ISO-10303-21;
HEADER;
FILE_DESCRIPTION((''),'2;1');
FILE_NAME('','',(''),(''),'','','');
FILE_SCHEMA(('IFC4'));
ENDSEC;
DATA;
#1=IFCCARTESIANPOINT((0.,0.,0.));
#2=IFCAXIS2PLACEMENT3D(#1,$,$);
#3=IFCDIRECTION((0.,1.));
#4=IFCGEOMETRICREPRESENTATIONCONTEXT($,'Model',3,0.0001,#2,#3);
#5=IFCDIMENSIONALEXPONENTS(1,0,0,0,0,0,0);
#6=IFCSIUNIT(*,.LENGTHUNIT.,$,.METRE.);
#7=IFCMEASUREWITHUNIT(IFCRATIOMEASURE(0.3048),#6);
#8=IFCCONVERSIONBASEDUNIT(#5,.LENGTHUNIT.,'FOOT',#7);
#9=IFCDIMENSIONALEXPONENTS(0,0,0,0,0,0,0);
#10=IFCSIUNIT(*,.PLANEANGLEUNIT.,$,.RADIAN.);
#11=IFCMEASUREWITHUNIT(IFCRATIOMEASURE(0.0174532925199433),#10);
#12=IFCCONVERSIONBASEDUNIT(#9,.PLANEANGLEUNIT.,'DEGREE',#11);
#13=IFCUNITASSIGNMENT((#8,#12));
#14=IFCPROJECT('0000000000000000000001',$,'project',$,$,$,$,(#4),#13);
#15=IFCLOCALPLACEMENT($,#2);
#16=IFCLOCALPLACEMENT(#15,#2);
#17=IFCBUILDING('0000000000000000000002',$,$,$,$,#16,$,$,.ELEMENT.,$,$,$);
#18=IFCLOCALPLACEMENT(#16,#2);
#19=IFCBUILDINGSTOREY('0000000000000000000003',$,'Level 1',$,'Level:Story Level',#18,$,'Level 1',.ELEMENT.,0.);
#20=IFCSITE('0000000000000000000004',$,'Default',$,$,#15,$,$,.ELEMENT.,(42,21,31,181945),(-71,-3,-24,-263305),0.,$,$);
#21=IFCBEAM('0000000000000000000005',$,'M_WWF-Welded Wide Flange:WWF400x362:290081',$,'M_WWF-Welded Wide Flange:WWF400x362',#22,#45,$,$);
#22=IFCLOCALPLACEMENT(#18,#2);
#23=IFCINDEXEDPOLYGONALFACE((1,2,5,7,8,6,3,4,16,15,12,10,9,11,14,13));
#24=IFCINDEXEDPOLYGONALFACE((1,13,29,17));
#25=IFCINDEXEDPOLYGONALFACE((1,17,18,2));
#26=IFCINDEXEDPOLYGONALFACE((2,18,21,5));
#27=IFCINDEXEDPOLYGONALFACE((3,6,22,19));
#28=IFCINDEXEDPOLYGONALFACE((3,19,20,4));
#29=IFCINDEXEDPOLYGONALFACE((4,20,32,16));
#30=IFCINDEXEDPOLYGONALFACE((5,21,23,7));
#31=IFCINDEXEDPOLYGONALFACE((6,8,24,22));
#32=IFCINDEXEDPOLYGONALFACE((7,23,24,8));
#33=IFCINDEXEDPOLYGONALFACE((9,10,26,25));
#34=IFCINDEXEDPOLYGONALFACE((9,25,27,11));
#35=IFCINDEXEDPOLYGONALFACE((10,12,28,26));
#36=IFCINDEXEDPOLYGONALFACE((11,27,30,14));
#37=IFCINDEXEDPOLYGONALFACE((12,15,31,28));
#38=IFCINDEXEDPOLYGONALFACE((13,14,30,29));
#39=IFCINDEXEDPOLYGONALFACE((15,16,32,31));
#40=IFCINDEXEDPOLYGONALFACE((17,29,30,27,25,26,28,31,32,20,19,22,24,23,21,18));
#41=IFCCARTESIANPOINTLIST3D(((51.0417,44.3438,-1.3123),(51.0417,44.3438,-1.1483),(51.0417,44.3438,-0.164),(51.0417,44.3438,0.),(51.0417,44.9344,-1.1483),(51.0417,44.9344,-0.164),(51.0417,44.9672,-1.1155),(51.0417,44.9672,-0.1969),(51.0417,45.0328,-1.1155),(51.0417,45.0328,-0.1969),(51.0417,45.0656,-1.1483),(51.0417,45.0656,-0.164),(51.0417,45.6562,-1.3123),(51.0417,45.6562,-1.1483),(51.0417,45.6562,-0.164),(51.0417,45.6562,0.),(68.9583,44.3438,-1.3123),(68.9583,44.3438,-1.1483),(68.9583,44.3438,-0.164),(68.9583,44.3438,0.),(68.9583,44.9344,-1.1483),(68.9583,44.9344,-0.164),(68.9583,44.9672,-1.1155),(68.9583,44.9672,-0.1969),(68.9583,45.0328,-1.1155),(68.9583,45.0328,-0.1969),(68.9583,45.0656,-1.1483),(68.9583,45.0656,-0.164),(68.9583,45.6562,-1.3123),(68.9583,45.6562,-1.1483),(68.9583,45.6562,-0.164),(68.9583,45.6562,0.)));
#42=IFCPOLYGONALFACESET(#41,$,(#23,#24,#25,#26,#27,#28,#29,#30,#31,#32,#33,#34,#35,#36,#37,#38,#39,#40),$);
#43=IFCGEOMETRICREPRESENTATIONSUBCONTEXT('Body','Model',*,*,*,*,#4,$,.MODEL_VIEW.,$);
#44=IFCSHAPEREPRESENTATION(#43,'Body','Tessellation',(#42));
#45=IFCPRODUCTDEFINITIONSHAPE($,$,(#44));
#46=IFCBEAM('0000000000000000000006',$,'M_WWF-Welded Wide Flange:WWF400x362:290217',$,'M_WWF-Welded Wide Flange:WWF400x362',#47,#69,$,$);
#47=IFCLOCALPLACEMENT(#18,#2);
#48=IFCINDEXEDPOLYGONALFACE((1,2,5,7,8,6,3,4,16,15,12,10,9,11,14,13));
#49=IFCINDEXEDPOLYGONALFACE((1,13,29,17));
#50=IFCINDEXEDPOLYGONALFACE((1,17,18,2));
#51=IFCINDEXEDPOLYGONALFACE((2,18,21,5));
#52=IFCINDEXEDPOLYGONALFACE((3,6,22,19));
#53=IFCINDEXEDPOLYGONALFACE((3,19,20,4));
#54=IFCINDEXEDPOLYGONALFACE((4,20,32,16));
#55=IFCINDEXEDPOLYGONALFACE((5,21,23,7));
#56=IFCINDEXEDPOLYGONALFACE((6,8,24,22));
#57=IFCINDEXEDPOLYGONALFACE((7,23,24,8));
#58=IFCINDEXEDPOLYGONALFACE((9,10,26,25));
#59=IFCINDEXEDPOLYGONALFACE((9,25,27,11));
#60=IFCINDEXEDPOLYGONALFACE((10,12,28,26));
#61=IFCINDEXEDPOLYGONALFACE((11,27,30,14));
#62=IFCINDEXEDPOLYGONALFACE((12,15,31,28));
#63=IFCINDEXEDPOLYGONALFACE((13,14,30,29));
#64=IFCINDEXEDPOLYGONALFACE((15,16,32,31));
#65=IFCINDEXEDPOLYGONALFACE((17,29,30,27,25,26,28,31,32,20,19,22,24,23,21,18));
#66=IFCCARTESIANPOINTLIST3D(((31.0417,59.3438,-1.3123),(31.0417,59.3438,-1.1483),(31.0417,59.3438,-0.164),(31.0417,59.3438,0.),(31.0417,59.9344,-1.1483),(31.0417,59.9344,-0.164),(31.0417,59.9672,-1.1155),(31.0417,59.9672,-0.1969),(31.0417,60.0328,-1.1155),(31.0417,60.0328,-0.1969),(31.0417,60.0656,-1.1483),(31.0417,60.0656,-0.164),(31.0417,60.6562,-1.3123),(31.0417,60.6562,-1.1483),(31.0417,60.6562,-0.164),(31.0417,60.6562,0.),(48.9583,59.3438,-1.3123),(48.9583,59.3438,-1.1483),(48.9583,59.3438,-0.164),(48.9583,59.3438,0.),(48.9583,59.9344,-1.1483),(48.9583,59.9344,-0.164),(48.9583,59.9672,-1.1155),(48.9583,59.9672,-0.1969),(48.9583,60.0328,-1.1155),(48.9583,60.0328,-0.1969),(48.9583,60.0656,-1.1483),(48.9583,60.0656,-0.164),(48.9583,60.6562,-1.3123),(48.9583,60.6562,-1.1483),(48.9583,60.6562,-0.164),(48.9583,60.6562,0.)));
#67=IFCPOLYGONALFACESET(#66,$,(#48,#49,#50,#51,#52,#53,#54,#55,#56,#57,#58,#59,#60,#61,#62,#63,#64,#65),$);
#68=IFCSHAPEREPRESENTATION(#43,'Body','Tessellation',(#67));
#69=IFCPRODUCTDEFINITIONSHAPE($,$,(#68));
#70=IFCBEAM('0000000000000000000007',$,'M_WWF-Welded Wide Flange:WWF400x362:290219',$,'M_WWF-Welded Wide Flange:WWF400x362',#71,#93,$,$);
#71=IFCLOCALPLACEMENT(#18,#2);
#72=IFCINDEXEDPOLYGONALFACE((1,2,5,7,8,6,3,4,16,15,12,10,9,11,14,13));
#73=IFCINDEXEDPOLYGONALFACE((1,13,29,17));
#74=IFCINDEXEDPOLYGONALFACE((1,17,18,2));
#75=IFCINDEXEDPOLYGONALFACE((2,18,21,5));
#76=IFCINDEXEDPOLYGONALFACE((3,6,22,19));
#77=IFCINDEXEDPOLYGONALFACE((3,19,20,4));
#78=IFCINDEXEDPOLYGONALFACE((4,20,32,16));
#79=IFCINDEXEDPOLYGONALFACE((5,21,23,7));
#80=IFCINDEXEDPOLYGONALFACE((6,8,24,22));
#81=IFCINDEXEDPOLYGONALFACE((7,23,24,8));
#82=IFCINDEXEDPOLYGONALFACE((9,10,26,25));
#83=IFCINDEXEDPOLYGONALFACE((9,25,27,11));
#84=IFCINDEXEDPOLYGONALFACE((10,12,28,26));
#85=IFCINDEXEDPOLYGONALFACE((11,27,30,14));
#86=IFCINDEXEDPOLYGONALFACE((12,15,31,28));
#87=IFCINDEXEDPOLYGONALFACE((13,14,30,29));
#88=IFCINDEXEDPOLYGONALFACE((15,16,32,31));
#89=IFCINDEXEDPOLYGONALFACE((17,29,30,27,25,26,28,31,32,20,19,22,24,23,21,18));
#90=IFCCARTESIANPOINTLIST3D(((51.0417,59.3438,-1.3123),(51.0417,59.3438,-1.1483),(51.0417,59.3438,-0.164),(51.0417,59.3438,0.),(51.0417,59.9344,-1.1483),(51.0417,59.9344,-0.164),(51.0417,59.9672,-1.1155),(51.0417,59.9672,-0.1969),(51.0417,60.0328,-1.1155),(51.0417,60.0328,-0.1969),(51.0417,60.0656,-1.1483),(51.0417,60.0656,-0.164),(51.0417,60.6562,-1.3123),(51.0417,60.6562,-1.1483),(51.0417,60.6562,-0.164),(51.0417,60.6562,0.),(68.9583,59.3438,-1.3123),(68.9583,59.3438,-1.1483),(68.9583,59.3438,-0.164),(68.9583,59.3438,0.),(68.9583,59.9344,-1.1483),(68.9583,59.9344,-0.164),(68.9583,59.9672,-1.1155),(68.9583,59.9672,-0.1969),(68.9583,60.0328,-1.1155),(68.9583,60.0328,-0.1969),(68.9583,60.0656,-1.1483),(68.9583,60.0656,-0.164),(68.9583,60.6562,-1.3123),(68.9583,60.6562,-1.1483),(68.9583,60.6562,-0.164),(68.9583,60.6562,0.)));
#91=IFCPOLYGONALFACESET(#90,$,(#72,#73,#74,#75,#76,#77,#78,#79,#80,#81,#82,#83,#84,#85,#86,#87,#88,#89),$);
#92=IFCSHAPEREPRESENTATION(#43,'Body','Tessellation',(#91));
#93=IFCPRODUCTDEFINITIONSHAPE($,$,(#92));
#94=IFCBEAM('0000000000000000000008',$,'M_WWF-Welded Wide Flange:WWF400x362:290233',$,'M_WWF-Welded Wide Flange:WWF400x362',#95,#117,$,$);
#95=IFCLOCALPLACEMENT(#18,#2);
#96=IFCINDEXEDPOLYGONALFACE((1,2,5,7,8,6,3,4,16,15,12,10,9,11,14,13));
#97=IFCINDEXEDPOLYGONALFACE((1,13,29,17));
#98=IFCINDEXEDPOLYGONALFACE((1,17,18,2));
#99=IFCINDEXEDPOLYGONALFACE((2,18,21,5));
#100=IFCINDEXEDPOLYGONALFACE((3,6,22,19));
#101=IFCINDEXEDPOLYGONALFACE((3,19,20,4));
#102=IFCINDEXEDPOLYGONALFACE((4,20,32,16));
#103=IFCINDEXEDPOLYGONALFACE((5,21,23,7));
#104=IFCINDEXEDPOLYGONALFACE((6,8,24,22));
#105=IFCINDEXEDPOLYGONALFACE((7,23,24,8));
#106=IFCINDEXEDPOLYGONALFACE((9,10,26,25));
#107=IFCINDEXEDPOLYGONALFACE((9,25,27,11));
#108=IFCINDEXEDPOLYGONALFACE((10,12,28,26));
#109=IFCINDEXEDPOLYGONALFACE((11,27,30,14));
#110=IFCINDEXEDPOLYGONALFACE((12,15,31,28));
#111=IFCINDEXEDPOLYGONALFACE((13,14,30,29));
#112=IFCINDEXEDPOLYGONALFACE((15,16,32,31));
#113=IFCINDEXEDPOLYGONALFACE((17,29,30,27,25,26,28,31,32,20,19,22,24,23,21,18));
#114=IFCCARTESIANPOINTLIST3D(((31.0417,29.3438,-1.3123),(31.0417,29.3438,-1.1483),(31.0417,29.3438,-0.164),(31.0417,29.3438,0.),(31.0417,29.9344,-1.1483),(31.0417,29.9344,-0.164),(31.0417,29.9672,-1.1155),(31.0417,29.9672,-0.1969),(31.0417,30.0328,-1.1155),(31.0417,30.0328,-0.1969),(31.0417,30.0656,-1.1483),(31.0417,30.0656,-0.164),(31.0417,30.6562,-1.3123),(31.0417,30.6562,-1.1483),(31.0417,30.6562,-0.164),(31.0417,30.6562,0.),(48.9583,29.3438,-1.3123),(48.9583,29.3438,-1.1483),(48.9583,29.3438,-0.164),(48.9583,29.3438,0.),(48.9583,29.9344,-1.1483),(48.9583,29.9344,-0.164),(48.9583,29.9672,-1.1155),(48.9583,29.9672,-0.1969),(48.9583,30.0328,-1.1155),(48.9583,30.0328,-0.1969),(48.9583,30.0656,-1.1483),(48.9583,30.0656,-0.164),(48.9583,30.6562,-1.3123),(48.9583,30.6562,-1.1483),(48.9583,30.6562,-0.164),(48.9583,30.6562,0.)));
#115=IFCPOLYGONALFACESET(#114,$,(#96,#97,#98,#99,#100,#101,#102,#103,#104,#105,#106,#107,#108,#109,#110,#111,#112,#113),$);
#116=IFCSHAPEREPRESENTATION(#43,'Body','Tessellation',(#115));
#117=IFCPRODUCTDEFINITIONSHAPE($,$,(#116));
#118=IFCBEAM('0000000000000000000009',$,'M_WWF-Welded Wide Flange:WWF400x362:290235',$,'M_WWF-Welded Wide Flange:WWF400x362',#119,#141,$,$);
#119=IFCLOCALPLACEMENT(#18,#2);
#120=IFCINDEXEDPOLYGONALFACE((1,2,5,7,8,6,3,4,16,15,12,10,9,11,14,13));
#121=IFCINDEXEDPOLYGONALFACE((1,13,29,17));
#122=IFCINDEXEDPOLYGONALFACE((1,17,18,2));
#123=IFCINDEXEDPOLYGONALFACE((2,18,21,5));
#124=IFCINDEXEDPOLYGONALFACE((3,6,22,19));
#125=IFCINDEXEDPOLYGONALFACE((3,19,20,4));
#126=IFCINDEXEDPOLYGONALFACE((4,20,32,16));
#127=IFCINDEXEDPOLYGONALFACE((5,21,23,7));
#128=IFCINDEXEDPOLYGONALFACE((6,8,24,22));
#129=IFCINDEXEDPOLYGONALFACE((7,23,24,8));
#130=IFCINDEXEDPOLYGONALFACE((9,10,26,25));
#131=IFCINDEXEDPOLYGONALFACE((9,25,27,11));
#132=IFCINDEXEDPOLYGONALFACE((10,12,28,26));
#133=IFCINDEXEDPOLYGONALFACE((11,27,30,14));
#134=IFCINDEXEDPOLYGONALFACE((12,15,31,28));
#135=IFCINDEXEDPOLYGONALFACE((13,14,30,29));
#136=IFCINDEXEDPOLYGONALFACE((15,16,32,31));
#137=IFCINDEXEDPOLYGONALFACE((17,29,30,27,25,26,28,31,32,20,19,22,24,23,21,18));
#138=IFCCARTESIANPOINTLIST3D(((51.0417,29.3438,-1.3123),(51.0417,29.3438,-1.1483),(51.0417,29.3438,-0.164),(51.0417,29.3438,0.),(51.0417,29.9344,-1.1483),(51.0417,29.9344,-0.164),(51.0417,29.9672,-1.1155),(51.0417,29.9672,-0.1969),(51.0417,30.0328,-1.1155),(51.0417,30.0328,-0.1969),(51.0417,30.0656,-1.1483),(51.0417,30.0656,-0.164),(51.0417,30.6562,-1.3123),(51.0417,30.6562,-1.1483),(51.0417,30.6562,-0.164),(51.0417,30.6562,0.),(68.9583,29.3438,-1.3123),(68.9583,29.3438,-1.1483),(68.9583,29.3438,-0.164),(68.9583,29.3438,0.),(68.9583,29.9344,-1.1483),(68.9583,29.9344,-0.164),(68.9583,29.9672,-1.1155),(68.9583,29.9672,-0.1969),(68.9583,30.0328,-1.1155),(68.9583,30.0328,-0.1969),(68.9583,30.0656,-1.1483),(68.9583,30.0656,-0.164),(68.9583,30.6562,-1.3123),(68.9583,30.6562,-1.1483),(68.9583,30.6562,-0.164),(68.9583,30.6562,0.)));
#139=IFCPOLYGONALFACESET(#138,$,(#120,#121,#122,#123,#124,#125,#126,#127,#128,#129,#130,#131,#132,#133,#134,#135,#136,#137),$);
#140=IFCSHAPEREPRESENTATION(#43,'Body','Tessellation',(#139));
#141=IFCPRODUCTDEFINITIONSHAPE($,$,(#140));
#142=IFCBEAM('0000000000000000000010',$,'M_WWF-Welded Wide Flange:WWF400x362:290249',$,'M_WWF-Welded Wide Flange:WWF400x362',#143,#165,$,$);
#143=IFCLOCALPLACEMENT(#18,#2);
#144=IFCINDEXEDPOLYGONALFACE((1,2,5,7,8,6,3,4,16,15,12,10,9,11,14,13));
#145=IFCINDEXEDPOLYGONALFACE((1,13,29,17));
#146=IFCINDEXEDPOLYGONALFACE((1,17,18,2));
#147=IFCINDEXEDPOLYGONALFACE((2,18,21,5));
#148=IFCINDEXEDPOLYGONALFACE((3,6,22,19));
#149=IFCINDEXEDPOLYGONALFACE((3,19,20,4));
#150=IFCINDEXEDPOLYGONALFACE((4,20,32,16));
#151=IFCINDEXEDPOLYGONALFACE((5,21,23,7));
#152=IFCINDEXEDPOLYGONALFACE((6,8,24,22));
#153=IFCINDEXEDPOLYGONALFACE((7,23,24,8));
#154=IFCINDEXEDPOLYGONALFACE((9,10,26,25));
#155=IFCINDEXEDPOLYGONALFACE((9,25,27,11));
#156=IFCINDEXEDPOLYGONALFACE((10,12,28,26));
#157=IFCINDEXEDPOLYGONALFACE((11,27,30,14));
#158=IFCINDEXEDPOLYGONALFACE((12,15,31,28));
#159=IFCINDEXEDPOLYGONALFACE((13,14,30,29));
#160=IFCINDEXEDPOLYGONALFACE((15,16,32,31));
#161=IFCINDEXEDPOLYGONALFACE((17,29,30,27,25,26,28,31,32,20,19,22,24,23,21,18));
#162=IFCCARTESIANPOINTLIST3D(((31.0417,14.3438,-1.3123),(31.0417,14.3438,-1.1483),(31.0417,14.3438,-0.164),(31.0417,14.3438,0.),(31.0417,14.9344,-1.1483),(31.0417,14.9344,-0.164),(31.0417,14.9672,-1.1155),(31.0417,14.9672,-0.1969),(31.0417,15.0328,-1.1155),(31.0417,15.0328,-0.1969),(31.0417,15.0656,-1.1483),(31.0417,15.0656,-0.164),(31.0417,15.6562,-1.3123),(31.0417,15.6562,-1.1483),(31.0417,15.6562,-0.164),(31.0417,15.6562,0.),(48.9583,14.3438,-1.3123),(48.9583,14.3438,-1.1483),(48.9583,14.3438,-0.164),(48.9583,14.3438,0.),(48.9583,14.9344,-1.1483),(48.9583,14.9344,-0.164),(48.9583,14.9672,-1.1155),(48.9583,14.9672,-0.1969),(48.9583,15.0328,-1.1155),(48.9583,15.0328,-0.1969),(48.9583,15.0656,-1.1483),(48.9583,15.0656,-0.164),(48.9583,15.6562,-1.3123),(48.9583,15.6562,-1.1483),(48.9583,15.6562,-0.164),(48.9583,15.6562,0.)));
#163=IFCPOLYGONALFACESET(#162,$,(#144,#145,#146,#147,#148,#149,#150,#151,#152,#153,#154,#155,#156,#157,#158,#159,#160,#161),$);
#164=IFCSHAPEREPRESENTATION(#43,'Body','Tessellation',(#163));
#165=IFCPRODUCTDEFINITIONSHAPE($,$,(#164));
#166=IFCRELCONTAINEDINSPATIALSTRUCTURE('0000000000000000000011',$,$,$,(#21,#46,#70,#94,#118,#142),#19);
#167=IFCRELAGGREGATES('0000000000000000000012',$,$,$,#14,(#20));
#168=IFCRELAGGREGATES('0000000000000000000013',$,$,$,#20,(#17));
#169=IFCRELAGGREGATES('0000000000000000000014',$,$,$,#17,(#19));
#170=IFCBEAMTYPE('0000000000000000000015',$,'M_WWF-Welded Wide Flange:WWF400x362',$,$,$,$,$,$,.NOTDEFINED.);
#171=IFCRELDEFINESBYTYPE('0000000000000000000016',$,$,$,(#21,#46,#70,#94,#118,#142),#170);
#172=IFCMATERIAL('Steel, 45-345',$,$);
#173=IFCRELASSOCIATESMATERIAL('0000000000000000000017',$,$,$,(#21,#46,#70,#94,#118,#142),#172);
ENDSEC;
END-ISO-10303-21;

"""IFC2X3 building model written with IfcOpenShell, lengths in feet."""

from ifc_helpers import new_model, entity, si_unit, converted_unit, direction, frame, origin, place, context, subcontext, project, spatial, polyline, outline, extrude, material, type_object, element, save


model = new_model("IFC2X3")

# Units and contexts
model_context = context("Model", 3, precision=0.0001, world=origin(), true_north=direction((0.0, 1.0)))
body_context = subcontext(model_context, "Body", "Model", "MODEL_VIEW")
ifc_project = project(units=[converted_unit("LENGTHUNIT", "FOOT", entity("IfcRatioMeasure", 0.3048), si_unit("LENGTHUNIT", "METRE"), dimensions=[1, 0, 0, 0, 0, 0, 0]), converted_unit("PLANEANGLEUNIT", "DEGREE", entity("IfcRatioMeasure", 0.0174532925199433), si_unit("PLANEANGLEUNIT", "RADIAN"), dimensions=[0, 0, 0, 0, 0, 0, 0])], contexts=[model_context])

# Site, building, storey
site_placement = place(None, origin())
site = spatial("IfcSite", under=ifc_project, at=site_placement, Name="Default", CompositionType="ELEMENT", RefLatitude=(42, 21, 31, 181945), RefLongitude=(-71, -3, -24, -263305), RefElevation=0.0)
building_placement = place(site_placement, origin())
building = spatial("IfcBuilding", under=site, at=building_placement, CompositionType="ELEMENT")
storey_placement = place(building_placement, origin())
storey = spatial("IfcBuildingStorey", under=building, at=storey_placement, Name="Level 1", ObjectType="Level:Story Level", LongName="Level 1", CompositionType="ELEMENT", Elevation=0.0)

# Shared definitions
ifc_material = material(Name="Steel, 45-345")

# Beams
beam_type = type_object("IfcBeamType", Name="M_WWF-Welded Wide Flange:WWF400x362", PredefinedType="NOTDEFINED")
beam_1_placement = place(storey_placement, frame((50.0, 45.0, 0.0)))
element("IfcBeam", 1, at=beam_1_placement, inside=storey, type_object=beam_type, material=ifc_material, Name="M_WWF-Welded Wide Flange:WWF400x362:290081", ObjectType="M_WWF-Welded Wide Flange:WWF400x362", context=body_context, shape_type="SweptSolid", body=[
    extrude(outline(polyline([(-0.6562, -0.6562), (-0.4921, -0.6562), (-0.4921, -0.0656), (-0.4593, -0.0328), (0.4593, -0.0328), (0.4921, -0.0656), (0.4921, -0.6562), (0.6562, -0.6562), (0.6562, 0.6562), (0.4921, 0.6562), (0.4921, 0.0656), (0.4593, 0.0328), (-0.4593, 0.0328), (-0.4921, 0.0656), (-0.4921, 0.6562), (-0.6562, 0.6562), (-0.6562, -0.6562)])), frame((1.0417, 0.0, -0.6562), z_axis=(1.0, 0.0, 0.0), x_axis=(0.0, 0.0, -1.0)), (0.0, 0.0, 1.0), 17.9167),
])
beam_2_placement = place(storey_placement, frame((30.0, 60.0, 0.0)))
element("IfcBeam", 2, at=beam_2_placement, inside=storey, type_object=beam_type, material=ifc_material, Name="M_WWF-Welded Wide Flange:WWF400x362:290217", ObjectType="M_WWF-Welded Wide Flange:WWF400x362", context=body_context, shape_type="SweptSolid", body=[
    extrude(outline(polyline([(-0.6562, -0.6562), (-0.4921, -0.6562), (-0.4921, -0.0656), (-0.4593, -0.0328), (0.4593, -0.0328), (0.4921, -0.0656), (0.4921, -0.6562), (0.6562, -0.6562), (0.6562, 0.6562), (0.4921, 0.6562), (0.4921, 0.0656), (0.4593, 0.0328), (-0.4593, 0.0328), (-0.4921, 0.0656), (-0.4921, 0.6562), (-0.6562, 0.6562), (-0.6562, -0.6562)])), frame((1.0417, 0.0, -0.6562), z_axis=(1.0, 0.0, 0.0), x_axis=(0.0, 0.0, -1.0)), (0.0, 0.0, 1.0), 17.9167),
])
beam_3_placement = place(storey_placement, frame((50.0, 60.0, 0.0)))
element("IfcBeam", 3, at=beam_3_placement, inside=storey, type_object=beam_type, material=ifc_material, Name="M_WWF-Welded Wide Flange:WWF400x362:290219", ObjectType="M_WWF-Welded Wide Flange:WWF400x362", context=body_context, shape_type="SweptSolid", body=[
    extrude(outline(polyline([(-0.6562, -0.6562), (-0.4921, -0.6562), (-0.4921, -0.0656), (-0.4593, -0.0328), (0.4593, -0.0328), (0.4921, -0.0656), (0.4921, -0.6562), (0.6562, -0.6562), (0.6562, 0.6562), (0.4921, 0.6562), (0.4921, 0.0656), (0.4593, 0.0328), (-0.4593, 0.0328), (-0.4921, 0.0656), (-0.4921, 0.6562), (-0.6562, 0.6562), (-0.6562, -0.6562)])), frame((1.0417, 0.0, -0.6562), z_axis=(1.0, 0.0, 0.0), x_axis=(0.0, 0.0, -1.0)), (0.0, 0.0, 1.0), 17.9167),
])
beam_4_placement = place(storey_placement, frame((30.0, 30.0, 0.0)))
element("IfcBeam", 4, at=beam_4_placement, inside=storey, type_object=beam_type, material=ifc_material, Name="M_WWF-Welded Wide Flange:WWF400x362:290233", ObjectType="M_WWF-Welded Wide Flange:WWF400x362", context=body_context, shape_type="SweptSolid", body=[
    extrude(outline(polyline([(-0.6562, -0.6562), (-0.4921, -0.6562), (-0.4921, -0.0656), (-0.4593, -0.0328), (0.4593, -0.0328), (0.4921, -0.0656), (0.4921, -0.6562), (0.6562, -0.6562), (0.6562, 0.6562), (0.4921, 0.6562), (0.4921, 0.0656), (0.4593, 0.0328), (-0.4593, 0.0328), (-0.4921, 0.0656), (-0.4921, 0.6562), (-0.6562, 0.6562), (-0.6562, -0.6562)])), frame((1.0417, 0.0, -0.6562), z_axis=(1.0, 0.0, 0.0), x_axis=(0.0, 0.0, -1.0)), (0.0, 0.0, 1.0), 17.9167),
])
beam_5_placement = place(storey_placement, frame((50.0, 30.0, 0.0)))
element("IfcBeam", 5, at=beam_5_placement, inside=storey, type_object=beam_type, material=ifc_material, Name="M_WWF-Welded Wide Flange:WWF400x362:290235", ObjectType="M_WWF-Welded Wide Flange:WWF400x362", context=body_context, shape_type="SweptSolid", body=[
    extrude(outline(polyline([(-0.6562, -0.6562), (-0.4921, -0.6562), (-0.4921, -0.0656), (-0.4593, -0.0328), (0.4593, -0.0328), (0.4921, -0.0656), (0.4921, -0.6562), (0.6562, -0.6562), (0.6562, 0.6562), (0.4921, 0.6562), (0.4921, 0.0656), (0.4593, 0.0328), (-0.4593, 0.0328), (-0.4921, 0.0656), (-0.4921, 0.6562), (-0.6562, 0.6562), (-0.6562, -0.6562)])), frame((1.0417, 0.0, -0.6562), z_axis=(1.0, 0.0, 0.0), x_axis=(0.0, 0.0, -1.0)), (0.0, 0.0, 1.0), 17.9167),
])
beam_6_placement = place(storey_placement, frame((30.0, 15.0, 0.0)))
element("IfcBeam", 6, at=beam_6_placement, inside=storey, type_object=beam_type, material=ifc_material, Name="M_WWF-Welded Wide Flange:WWF400x362:290249", ObjectType="M_WWF-Welded Wide Flange:WWF400x362", context=body_context, shape_type="SweptSolid", body=[
    extrude(outline(polyline([(-0.6562, -0.6562), (-0.4921, -0.6562), (-0.4921, -0.0656), (-0.4593, -0.0328), (0.4593, -0.0328), (0.4921, -0.0656), (0.4921, -0.6562), (0.6562, -0.6562), (0.6562, 0.6562), (0.4921, 0.6562), (0.4921, 0.0656), (0.4593, 0.0328), (-0.4593, 0.0328), (-0.4921, 0.0656), (-0.4921, 0.6562), (-0.6562, 0.6562), (-0.6562, -0.6562)])), frame((1.0417, 0.0, -0.6562), z_axis=(1.0, 0.0, 0.0), x_axis=(0.0, 0.0, -1.0)), (0.0, 0.0, 1.0), 17.9167),
])

save(model, "model.ifc")
